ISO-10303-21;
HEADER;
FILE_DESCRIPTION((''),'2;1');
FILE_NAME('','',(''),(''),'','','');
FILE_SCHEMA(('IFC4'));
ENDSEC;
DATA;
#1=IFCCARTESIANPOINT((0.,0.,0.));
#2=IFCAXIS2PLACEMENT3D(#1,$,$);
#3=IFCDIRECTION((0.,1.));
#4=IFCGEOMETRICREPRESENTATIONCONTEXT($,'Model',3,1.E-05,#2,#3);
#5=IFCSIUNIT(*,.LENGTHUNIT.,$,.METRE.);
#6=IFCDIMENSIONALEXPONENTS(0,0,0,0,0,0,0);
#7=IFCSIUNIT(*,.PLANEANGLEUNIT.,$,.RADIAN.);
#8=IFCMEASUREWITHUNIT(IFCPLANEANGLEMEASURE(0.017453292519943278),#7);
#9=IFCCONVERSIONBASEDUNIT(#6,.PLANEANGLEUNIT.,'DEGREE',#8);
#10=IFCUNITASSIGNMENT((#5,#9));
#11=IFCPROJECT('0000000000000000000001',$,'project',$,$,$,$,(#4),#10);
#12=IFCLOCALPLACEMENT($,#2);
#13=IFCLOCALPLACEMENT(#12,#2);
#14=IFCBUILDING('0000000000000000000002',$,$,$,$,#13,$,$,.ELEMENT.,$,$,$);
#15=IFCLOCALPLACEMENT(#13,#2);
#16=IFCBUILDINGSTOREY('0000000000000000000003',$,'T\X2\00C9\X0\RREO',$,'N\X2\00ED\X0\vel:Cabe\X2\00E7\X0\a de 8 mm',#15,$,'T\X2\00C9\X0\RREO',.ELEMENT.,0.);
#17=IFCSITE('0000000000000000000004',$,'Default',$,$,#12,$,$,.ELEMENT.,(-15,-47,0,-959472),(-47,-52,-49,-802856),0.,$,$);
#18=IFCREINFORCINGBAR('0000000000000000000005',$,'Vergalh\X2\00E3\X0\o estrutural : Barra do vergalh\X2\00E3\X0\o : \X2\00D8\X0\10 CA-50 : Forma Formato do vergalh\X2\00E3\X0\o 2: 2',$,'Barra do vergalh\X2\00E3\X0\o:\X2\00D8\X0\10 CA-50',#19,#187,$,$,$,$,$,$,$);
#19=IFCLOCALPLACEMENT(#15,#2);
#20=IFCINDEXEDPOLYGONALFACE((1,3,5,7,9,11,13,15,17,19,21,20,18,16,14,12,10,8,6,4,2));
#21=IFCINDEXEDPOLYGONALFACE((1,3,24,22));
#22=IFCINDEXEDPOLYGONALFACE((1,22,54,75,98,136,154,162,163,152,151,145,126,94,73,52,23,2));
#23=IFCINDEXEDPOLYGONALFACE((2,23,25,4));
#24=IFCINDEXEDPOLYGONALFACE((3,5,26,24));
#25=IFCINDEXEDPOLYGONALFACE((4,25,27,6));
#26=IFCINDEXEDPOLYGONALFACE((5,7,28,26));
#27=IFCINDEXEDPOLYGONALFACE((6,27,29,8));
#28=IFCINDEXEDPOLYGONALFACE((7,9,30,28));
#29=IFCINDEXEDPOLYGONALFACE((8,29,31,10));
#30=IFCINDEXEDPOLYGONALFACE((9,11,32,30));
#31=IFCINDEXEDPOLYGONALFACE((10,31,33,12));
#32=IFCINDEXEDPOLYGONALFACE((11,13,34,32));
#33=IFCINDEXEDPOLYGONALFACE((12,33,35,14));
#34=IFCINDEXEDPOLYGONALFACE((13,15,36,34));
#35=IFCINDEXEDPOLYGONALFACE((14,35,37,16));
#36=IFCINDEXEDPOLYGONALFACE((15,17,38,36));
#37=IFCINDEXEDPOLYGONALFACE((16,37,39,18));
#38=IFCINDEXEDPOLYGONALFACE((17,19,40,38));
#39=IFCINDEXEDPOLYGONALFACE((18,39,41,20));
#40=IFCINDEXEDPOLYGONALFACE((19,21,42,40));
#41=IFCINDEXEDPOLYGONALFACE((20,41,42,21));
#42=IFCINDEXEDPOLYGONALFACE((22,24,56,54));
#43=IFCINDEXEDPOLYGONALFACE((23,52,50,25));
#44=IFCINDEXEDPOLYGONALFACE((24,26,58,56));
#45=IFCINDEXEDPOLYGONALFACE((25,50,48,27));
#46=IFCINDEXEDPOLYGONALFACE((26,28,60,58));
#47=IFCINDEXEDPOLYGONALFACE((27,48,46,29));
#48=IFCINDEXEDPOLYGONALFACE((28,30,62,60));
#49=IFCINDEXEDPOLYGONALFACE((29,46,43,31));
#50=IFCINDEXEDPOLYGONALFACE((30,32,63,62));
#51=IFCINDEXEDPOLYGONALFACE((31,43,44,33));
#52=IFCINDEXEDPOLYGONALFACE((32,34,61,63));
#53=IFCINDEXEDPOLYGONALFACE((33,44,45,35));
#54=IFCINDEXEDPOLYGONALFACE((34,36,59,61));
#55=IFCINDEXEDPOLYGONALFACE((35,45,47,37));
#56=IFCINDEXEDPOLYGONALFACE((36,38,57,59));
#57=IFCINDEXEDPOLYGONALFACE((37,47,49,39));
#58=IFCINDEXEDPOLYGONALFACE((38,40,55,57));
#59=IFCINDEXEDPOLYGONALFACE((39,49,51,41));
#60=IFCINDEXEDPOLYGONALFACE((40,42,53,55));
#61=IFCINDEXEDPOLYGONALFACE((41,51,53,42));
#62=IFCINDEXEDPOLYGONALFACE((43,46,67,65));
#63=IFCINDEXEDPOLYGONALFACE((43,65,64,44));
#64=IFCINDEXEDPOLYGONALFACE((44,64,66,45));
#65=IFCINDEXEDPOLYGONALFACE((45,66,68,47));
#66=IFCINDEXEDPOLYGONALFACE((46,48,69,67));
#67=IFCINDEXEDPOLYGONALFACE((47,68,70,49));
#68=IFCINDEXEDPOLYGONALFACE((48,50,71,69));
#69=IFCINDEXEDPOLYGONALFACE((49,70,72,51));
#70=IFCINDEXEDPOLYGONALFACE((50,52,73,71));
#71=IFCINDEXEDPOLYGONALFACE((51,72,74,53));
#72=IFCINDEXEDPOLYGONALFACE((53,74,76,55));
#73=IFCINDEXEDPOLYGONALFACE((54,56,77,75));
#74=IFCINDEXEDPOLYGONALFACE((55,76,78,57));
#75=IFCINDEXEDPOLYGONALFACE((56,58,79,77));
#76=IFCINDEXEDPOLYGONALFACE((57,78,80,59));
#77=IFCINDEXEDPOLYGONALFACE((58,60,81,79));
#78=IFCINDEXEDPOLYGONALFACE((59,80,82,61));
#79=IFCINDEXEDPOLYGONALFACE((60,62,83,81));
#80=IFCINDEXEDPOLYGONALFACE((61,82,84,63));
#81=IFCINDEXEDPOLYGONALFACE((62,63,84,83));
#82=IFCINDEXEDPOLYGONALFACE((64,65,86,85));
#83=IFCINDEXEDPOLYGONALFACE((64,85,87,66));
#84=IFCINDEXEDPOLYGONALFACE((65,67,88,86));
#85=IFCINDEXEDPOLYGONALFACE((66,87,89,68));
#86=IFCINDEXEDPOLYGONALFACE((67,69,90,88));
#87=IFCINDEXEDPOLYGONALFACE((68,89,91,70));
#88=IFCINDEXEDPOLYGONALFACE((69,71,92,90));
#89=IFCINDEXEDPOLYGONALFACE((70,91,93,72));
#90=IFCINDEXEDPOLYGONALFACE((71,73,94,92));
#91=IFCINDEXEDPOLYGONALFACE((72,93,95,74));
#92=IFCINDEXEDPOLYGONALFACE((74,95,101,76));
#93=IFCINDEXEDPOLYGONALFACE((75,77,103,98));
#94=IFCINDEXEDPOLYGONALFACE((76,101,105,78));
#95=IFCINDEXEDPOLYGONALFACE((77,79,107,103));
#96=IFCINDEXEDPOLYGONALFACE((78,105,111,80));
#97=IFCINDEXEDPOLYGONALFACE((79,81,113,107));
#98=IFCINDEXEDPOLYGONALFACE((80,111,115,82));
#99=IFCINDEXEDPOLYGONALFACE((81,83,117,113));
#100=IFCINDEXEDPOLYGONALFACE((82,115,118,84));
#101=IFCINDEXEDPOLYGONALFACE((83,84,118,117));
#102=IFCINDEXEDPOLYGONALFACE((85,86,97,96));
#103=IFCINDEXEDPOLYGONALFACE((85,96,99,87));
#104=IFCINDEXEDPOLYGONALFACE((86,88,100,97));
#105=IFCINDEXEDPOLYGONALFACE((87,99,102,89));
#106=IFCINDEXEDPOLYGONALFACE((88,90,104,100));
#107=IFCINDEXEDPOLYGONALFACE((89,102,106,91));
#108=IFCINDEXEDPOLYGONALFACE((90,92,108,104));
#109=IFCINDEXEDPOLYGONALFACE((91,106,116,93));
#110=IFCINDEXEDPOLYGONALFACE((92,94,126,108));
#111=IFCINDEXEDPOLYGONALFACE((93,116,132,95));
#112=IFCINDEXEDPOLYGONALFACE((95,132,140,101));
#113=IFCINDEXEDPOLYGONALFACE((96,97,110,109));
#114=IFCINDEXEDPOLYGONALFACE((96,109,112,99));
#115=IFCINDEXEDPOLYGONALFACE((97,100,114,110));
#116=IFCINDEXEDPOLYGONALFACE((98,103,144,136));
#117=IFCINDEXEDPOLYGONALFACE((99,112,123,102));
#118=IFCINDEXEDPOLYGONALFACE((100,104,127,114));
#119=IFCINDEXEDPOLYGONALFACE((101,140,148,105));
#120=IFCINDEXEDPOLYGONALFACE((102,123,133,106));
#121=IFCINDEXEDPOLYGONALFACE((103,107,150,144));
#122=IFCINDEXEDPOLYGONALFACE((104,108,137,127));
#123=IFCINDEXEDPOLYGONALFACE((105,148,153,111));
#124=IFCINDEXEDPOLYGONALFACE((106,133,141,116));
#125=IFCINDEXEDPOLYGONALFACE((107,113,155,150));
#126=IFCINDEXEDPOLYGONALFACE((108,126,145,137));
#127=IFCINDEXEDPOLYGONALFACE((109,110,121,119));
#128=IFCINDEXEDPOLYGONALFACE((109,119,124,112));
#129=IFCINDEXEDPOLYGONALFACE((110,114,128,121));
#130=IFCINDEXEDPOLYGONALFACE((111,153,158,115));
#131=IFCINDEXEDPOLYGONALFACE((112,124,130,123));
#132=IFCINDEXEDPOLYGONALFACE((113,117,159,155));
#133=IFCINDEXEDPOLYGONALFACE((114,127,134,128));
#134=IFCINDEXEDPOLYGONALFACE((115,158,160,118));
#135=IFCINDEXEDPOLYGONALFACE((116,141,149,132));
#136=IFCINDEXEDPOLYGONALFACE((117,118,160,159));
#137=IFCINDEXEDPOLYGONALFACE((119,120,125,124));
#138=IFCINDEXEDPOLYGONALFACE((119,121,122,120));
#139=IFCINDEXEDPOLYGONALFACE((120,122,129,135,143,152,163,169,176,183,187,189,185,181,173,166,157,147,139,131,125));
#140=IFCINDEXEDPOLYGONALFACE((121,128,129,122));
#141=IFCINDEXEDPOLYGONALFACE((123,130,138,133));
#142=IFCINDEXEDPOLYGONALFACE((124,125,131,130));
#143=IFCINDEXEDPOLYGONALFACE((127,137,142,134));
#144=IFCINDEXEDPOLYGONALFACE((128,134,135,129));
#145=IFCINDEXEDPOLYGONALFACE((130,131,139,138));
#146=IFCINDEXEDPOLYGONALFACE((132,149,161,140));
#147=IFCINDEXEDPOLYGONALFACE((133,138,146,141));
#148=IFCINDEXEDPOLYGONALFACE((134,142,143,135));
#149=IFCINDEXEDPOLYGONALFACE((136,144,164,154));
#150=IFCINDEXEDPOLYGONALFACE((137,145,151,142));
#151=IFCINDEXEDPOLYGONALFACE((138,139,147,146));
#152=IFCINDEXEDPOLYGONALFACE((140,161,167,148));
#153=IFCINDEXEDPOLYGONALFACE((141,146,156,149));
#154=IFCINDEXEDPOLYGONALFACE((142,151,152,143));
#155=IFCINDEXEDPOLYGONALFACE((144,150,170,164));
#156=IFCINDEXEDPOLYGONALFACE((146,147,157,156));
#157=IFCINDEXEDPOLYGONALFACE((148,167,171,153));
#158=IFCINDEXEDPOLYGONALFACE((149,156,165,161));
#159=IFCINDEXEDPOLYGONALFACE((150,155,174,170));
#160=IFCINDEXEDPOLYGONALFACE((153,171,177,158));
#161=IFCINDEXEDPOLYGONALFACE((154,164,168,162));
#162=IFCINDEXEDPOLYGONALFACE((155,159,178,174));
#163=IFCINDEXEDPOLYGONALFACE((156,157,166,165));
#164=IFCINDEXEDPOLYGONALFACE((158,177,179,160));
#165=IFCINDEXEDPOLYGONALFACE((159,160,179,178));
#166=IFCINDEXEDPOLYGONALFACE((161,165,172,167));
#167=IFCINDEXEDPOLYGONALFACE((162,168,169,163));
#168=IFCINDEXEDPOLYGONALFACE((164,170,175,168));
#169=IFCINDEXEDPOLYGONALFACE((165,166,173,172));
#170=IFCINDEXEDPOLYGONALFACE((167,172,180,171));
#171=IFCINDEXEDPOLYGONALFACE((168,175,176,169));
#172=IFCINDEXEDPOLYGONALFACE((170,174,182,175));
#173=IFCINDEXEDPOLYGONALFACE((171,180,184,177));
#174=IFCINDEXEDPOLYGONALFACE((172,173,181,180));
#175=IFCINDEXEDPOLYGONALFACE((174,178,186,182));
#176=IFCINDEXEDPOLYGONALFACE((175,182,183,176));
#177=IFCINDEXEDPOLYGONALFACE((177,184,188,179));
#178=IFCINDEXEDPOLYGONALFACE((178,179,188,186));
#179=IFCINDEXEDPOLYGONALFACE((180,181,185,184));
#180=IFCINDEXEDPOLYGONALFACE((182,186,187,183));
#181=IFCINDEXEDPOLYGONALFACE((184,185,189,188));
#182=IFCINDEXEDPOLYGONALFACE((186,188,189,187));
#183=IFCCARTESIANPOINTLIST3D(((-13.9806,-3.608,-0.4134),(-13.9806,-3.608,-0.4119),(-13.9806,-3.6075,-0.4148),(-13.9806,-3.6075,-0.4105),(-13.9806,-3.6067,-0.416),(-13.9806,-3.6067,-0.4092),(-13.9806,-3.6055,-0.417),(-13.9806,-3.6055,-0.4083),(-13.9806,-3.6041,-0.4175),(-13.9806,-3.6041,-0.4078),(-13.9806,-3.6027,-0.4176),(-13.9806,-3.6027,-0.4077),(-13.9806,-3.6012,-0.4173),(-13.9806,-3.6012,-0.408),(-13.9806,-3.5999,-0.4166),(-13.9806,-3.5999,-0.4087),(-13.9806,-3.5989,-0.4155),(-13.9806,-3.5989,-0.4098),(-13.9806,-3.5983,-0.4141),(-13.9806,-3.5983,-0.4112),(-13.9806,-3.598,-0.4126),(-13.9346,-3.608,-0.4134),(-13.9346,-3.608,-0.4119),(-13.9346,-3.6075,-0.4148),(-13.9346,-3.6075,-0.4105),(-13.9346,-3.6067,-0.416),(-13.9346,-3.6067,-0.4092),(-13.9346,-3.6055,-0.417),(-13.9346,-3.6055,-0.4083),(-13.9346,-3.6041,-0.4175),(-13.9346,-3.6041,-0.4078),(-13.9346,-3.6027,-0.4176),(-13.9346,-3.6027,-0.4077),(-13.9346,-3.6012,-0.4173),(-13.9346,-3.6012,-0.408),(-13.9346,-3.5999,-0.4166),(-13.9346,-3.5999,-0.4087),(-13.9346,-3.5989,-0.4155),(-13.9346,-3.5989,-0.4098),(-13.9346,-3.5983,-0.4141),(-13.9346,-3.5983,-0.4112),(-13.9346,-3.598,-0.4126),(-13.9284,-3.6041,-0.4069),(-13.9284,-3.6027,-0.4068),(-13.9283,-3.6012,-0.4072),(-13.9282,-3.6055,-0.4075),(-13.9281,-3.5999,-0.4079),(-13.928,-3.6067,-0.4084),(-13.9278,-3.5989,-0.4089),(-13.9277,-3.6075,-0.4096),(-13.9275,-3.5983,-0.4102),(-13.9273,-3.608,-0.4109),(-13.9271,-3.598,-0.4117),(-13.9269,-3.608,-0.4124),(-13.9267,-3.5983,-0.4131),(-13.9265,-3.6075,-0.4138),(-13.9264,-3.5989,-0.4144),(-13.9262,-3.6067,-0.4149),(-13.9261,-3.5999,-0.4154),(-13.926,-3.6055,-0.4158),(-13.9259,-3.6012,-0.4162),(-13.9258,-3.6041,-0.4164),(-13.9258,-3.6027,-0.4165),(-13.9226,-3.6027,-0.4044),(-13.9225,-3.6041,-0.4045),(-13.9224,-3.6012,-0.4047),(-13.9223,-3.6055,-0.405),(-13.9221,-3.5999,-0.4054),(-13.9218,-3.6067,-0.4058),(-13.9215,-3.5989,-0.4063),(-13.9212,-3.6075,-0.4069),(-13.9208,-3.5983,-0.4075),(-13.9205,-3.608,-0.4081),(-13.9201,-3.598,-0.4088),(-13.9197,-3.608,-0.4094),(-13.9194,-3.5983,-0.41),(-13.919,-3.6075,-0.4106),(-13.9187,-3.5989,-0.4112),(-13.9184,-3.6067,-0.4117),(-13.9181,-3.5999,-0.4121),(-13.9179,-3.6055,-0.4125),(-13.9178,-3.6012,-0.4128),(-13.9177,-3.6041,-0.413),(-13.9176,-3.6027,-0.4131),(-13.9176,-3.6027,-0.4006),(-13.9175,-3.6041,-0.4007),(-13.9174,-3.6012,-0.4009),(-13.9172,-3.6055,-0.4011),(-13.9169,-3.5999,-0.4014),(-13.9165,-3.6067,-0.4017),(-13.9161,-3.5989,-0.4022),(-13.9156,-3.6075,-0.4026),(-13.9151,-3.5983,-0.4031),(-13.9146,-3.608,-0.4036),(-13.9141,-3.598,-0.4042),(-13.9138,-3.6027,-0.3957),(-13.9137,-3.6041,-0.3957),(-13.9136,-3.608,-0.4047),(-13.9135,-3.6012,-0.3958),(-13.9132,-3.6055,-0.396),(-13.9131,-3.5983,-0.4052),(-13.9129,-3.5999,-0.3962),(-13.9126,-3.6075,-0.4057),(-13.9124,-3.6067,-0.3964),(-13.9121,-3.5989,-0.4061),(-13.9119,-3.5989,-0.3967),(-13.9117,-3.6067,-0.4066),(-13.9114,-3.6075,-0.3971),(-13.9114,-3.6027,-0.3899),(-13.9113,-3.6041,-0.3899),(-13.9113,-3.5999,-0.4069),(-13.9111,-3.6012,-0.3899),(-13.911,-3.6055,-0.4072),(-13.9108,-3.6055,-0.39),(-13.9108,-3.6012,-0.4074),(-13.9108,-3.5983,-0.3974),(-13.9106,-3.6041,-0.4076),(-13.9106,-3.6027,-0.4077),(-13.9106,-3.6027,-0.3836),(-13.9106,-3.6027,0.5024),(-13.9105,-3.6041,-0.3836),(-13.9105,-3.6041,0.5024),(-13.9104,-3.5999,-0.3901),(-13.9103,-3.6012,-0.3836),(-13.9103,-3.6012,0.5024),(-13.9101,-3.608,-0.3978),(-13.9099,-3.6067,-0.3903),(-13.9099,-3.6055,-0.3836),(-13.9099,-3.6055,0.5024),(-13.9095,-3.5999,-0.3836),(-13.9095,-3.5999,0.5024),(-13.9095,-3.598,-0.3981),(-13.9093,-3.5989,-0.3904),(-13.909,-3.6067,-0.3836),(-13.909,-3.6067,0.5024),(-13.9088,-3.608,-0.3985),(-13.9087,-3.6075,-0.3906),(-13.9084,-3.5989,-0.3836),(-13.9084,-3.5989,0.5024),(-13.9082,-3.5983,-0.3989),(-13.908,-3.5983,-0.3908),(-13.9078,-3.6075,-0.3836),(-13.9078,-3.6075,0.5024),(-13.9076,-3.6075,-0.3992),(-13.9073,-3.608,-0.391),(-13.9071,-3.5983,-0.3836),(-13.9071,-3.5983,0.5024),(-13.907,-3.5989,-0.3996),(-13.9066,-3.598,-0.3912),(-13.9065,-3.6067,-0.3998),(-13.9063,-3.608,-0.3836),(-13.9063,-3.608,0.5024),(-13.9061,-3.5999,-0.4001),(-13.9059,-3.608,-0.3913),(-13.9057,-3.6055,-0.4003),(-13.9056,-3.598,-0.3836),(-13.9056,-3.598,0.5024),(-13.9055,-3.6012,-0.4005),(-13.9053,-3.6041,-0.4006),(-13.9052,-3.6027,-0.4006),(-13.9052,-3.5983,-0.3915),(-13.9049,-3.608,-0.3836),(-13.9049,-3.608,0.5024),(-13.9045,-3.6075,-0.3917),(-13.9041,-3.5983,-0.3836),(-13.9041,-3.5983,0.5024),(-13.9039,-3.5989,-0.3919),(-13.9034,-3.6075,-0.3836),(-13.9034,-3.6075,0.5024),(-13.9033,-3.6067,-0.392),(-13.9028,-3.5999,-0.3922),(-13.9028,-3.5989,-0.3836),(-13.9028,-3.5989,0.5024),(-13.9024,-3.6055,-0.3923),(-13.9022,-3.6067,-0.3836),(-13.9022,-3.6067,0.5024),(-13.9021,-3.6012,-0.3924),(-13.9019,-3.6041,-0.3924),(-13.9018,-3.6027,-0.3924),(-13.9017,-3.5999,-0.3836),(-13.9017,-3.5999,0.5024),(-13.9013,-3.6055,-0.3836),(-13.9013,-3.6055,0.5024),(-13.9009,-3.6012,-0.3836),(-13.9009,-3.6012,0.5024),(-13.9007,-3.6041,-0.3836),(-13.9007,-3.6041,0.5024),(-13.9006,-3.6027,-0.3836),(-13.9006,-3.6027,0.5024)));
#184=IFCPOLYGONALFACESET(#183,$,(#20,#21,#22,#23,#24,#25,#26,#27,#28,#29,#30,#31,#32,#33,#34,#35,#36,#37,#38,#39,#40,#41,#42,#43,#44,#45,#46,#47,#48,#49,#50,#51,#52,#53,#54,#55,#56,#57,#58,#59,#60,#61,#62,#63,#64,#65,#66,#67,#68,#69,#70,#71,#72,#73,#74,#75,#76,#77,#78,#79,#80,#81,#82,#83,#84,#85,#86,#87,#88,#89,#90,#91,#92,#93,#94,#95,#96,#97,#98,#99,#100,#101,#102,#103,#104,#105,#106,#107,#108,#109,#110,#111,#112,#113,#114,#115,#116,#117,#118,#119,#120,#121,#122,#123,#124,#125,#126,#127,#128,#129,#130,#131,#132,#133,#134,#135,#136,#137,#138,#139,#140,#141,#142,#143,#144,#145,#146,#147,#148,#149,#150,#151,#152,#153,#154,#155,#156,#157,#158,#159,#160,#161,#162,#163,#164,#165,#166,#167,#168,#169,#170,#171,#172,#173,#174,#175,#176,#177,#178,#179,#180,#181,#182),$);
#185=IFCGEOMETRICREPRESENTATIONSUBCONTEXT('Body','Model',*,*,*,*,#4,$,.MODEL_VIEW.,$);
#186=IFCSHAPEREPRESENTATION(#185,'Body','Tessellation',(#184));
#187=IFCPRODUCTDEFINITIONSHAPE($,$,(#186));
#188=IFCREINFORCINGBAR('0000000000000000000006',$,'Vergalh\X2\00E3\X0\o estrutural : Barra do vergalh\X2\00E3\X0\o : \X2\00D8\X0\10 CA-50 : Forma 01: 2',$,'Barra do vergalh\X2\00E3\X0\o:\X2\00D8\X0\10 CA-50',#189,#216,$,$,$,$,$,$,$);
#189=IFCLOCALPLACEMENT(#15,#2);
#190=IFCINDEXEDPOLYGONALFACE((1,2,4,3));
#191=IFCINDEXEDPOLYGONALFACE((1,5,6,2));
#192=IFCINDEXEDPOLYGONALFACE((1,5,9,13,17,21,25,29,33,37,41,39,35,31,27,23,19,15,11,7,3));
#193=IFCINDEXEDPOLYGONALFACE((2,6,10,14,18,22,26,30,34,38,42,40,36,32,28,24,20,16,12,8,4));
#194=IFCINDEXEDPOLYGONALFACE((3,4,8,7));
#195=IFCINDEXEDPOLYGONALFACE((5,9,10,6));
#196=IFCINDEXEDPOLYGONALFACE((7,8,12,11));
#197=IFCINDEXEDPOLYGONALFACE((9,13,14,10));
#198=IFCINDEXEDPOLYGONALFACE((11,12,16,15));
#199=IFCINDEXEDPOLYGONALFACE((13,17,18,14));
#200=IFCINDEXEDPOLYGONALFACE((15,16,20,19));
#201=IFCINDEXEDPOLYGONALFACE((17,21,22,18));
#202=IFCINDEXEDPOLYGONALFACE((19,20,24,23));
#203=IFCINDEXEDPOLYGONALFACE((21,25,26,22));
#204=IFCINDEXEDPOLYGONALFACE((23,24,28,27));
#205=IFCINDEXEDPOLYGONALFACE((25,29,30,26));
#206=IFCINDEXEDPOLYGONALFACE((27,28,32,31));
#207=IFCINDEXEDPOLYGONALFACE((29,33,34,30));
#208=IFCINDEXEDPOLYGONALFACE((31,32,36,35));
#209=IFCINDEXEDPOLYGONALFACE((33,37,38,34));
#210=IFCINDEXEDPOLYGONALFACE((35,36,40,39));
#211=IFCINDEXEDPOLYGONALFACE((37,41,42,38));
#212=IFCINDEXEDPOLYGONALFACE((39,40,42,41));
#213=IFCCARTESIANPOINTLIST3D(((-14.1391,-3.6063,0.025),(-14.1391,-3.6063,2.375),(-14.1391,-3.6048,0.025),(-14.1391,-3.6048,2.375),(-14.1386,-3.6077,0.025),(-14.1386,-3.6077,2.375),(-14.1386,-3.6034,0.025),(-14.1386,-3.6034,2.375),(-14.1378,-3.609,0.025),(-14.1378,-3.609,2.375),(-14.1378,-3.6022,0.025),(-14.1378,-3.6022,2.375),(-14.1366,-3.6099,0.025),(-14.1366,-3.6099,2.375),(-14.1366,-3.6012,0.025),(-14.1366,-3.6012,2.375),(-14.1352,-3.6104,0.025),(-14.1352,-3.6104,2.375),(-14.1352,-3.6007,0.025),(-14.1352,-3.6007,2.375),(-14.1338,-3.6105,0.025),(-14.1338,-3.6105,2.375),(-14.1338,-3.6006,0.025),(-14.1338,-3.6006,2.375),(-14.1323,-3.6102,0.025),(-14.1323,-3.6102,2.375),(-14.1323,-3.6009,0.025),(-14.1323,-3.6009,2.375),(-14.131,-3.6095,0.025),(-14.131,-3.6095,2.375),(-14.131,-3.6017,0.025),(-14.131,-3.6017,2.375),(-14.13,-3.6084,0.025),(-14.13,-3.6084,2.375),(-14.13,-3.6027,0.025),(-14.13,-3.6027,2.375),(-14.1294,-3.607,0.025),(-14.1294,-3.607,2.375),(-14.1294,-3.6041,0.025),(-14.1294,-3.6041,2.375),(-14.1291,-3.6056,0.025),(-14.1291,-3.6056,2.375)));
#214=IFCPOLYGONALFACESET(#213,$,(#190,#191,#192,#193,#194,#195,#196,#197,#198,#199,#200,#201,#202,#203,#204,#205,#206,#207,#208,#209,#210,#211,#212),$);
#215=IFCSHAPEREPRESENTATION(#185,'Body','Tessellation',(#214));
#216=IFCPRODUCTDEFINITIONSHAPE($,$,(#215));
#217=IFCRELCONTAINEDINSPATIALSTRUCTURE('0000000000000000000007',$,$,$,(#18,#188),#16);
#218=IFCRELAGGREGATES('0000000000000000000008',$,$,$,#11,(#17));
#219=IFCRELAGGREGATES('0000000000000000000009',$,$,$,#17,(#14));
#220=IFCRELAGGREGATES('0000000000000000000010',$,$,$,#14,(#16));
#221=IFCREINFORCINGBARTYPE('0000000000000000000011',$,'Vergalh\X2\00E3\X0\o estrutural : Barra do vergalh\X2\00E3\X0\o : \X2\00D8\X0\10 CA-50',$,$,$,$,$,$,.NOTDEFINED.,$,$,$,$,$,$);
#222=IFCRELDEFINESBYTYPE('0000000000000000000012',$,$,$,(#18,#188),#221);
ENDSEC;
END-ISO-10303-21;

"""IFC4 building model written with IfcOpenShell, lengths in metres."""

from ifc_helpers import new_model, entity, si_unit, converted_unit, direction, origin, place, context, subcontext, project, spatial, type_object, element, save


model = new_model("IFC4")

# Units and contexts
model_context = context("Model", 3, precision=1e-05, world=origin(), true_north=direction((0.0, 1.0)))
body_context = subcontext(model_context, "Body", "Model", "MODEL_VIEW")
ifc_project = project(units=[si_unit("LENGTHUNIT", "METRE"), converted_unit("PLANEANGLEUNIT", "DEGREE", entity("IfcPlaneAngleMeasure", 0.017453292519943278), si_unit("PLANEANGLEUNIT", "RADIAN"), dimensions=[0, 0, 0, 0, 0, 0, 0])], contexts=[model_context])

# Site, building, storey
site_placement = place(None, origin())
site = spatial("IfcSite", under=ifc_project, at=site_placement, Name="Default", CompositionType="ELEMENT", RefLatitude=(-15, -47, 0, -959472), RefLongitude=(-47, -52, -49, -802856), RefElevation=0.0)
building_placement = place(site_placement, origin())
building = spatial("IfcBuilding", under=site, at=building_placement, CompositionType="ELEMENT")
storey_placement = place(building_placement, origin())
storey = spatial("IfcBuildingStorey", under=building, at=storey_placement, Name="TÉRREO", ObjectType="Nível:Cabeça de 8 mm", LongName="TÉRREO", CompositionType="ELEMENT", Elevation=0.0)

# Reinforcing bars
reinforcing_bar_type_1 = type_object("IfcReinforcingBarType", Name="Vergalhão estrutural : Barra do vergalhão : Ø10 CA-50", PredefinedType="NOTDEFINED")
reinforcing_bar_1_placement = place(storey_placement, origin())
element("IfcReinforcingBar", 1, at=reinforcing_bar_1_placement, inside=storey, type_object=reinforcing_bar_type_1, Name="Vergalhão estrutural : Barra do vergalhão : Ø10 CA-50 : Forma Formato do vergalhão 2: 2", ObjectType="Barra do vergalhão:Ø10 CA-50", context=body_context, shape_type="AdvancedSweptSolid", body=[
    entity("IfcSweptDiskSolid", entity("IfcIndexedPolyCurve", entity("IfcCartesianPointList3D", [[-13.9806, -3.603, -0.4126], [-13.9346, -3.603, -0.4126], [-13.9141, -3.603, -0.4042], [-13.9056, -3.603, -0.3836], [-13.9056, -3.603, 0.5024]]), [entity("IfcLineIndex", [1, 2]), entity("IfcArcIndex", [2, 3, 4]), entity("IfcLineIndex", [4, 5])], False), 0.005, None, 0.0, 92.0),
])
reinforcing_bar_2_placement = place(storey_placement, origin())
element("IfcReinforcingBar", 2, at=reinforcing_bar_2_placement, inside=storey, type_object=reinforcing_bar_type_1, Name="Vergalhão estrutural : Barra do vergalhão : Ø10 CA-50 : Forma 01: 2", ObjectType="Barra do vergalhão:Ø10 CA-50", context=body_context, shape_type="AdvancedSweptSolid", body=[
    entity("IfcSweptDiskSolid", entity("IfcIndexedPolyCurve", entity("IfcCartesianPointList3D", [[-14.1341, -3.6056, 0.025], [-14.1341, -3.6056, 2.375]]), None, False), 0.005, None, 0.0, 1.0),
])

save(model, "model.ifc")
